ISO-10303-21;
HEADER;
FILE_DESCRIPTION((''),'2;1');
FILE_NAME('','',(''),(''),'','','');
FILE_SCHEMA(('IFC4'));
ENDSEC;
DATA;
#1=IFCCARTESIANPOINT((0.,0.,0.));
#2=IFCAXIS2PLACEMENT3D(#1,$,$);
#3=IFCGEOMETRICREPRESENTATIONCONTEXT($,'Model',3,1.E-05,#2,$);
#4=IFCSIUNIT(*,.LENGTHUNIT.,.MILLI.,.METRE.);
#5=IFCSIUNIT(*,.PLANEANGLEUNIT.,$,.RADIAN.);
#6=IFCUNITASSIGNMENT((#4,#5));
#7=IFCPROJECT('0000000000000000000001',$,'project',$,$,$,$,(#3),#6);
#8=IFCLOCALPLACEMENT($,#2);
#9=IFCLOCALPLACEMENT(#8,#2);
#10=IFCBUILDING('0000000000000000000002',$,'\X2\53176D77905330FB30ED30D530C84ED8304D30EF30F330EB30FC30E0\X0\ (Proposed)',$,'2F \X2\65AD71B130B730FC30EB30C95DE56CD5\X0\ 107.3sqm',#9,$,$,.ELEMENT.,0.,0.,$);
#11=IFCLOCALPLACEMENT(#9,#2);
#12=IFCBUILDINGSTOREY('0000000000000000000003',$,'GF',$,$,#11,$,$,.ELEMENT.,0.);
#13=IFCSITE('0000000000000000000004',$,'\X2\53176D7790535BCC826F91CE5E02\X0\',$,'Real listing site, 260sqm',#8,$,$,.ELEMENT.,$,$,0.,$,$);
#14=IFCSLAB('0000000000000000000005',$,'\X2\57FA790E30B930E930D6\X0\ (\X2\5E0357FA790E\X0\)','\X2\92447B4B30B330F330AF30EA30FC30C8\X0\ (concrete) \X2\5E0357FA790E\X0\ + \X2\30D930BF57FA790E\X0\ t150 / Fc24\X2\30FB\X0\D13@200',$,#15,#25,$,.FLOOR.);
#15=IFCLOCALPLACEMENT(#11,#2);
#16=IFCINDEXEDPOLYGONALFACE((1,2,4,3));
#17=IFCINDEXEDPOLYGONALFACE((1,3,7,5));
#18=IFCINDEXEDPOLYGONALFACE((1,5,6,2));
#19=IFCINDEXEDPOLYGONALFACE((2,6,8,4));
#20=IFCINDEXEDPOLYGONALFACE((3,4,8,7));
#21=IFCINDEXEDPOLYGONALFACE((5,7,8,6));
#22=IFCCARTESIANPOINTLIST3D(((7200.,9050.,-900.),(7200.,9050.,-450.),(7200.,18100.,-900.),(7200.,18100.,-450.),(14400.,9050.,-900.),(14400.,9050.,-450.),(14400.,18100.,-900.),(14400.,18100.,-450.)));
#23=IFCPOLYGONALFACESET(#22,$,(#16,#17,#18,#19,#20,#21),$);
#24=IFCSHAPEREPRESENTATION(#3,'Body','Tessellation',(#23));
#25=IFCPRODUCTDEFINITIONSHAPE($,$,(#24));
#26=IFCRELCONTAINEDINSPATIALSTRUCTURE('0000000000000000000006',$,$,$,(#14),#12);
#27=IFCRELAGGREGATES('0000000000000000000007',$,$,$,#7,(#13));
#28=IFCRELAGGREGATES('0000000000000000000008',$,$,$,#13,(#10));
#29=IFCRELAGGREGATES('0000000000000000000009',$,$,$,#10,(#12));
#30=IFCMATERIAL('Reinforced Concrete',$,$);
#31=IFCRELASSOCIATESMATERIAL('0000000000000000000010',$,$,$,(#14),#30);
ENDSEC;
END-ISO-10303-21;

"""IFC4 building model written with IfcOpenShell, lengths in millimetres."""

from ifc_helpers import new_model, si_unit, frame, frame_2d, origin, place, context, project, spatial, rectangle, extrude, material, element, save


model = new_model("IFC4")

# Units and contexts
model_context = context("Model", 3, precision=1e-05, world=origin())
ifc_project = project(units=[si_unit("LENGTHUNIT", "METRE", prefix="MILLI"), si_unit("PLANEANGLEUNIT", "RADIAN")], contexts=[model_context])

# Site, building, storey
site_placement = place(None, origin())
site = spatial("IfcSite", under=ifc_project, at=site_placement, Name="北海道富良野市", ObjectType="Real listing site, 260sqm", CompositionType="ELEMENT", RefElevation=0.0)
building_placement = place(site_placement, origin())
building = spatial("IfcBuilding", under=site, at=building_placement, Name="北海道・ロフト付きワンルーム (Proposed)", ObjectType="2F 断熱シールド工法 107.3sqm", CompositionType="ELEMENT", ElevationOfRefHeight=0.0, ElevationOfTerrain=0.0)
storey_placement = place(building_placement, origin())
storey = spatial("IfcBuildingStorey", under=building, at=storey_placement, Name="GF", CompositionType="ELEMENT", Elevation=0.0)

# Slab
ifc_material_1 = material(Name="Reinforced Concrete")
slab_1_placement = place(storey_placement, frame((3600.0, 4525.0, -450.0)))
element("IfcSlab", 1, at=slab_1_placement, inside=storey, material=ifc_material_1, Name="基礎スラブ (布基礎)", Description="鉄筋コンクリート (concrete) 布基礎 + ベタ基礎 t150 / Fc24・D13@200", PredefinedType="FLOOR", context=model_context, shape_type="SweptSolid", body=[
    extrude(rectangle(XDim=7200.0, YDim=9050.0, at=frame_2d((3600.0, 4525.0))), frame((3600.0, 4525.0, -450.0)), (0.0, 0.0, 1.0), 450.0),
])

save(model, "model.ifc")
